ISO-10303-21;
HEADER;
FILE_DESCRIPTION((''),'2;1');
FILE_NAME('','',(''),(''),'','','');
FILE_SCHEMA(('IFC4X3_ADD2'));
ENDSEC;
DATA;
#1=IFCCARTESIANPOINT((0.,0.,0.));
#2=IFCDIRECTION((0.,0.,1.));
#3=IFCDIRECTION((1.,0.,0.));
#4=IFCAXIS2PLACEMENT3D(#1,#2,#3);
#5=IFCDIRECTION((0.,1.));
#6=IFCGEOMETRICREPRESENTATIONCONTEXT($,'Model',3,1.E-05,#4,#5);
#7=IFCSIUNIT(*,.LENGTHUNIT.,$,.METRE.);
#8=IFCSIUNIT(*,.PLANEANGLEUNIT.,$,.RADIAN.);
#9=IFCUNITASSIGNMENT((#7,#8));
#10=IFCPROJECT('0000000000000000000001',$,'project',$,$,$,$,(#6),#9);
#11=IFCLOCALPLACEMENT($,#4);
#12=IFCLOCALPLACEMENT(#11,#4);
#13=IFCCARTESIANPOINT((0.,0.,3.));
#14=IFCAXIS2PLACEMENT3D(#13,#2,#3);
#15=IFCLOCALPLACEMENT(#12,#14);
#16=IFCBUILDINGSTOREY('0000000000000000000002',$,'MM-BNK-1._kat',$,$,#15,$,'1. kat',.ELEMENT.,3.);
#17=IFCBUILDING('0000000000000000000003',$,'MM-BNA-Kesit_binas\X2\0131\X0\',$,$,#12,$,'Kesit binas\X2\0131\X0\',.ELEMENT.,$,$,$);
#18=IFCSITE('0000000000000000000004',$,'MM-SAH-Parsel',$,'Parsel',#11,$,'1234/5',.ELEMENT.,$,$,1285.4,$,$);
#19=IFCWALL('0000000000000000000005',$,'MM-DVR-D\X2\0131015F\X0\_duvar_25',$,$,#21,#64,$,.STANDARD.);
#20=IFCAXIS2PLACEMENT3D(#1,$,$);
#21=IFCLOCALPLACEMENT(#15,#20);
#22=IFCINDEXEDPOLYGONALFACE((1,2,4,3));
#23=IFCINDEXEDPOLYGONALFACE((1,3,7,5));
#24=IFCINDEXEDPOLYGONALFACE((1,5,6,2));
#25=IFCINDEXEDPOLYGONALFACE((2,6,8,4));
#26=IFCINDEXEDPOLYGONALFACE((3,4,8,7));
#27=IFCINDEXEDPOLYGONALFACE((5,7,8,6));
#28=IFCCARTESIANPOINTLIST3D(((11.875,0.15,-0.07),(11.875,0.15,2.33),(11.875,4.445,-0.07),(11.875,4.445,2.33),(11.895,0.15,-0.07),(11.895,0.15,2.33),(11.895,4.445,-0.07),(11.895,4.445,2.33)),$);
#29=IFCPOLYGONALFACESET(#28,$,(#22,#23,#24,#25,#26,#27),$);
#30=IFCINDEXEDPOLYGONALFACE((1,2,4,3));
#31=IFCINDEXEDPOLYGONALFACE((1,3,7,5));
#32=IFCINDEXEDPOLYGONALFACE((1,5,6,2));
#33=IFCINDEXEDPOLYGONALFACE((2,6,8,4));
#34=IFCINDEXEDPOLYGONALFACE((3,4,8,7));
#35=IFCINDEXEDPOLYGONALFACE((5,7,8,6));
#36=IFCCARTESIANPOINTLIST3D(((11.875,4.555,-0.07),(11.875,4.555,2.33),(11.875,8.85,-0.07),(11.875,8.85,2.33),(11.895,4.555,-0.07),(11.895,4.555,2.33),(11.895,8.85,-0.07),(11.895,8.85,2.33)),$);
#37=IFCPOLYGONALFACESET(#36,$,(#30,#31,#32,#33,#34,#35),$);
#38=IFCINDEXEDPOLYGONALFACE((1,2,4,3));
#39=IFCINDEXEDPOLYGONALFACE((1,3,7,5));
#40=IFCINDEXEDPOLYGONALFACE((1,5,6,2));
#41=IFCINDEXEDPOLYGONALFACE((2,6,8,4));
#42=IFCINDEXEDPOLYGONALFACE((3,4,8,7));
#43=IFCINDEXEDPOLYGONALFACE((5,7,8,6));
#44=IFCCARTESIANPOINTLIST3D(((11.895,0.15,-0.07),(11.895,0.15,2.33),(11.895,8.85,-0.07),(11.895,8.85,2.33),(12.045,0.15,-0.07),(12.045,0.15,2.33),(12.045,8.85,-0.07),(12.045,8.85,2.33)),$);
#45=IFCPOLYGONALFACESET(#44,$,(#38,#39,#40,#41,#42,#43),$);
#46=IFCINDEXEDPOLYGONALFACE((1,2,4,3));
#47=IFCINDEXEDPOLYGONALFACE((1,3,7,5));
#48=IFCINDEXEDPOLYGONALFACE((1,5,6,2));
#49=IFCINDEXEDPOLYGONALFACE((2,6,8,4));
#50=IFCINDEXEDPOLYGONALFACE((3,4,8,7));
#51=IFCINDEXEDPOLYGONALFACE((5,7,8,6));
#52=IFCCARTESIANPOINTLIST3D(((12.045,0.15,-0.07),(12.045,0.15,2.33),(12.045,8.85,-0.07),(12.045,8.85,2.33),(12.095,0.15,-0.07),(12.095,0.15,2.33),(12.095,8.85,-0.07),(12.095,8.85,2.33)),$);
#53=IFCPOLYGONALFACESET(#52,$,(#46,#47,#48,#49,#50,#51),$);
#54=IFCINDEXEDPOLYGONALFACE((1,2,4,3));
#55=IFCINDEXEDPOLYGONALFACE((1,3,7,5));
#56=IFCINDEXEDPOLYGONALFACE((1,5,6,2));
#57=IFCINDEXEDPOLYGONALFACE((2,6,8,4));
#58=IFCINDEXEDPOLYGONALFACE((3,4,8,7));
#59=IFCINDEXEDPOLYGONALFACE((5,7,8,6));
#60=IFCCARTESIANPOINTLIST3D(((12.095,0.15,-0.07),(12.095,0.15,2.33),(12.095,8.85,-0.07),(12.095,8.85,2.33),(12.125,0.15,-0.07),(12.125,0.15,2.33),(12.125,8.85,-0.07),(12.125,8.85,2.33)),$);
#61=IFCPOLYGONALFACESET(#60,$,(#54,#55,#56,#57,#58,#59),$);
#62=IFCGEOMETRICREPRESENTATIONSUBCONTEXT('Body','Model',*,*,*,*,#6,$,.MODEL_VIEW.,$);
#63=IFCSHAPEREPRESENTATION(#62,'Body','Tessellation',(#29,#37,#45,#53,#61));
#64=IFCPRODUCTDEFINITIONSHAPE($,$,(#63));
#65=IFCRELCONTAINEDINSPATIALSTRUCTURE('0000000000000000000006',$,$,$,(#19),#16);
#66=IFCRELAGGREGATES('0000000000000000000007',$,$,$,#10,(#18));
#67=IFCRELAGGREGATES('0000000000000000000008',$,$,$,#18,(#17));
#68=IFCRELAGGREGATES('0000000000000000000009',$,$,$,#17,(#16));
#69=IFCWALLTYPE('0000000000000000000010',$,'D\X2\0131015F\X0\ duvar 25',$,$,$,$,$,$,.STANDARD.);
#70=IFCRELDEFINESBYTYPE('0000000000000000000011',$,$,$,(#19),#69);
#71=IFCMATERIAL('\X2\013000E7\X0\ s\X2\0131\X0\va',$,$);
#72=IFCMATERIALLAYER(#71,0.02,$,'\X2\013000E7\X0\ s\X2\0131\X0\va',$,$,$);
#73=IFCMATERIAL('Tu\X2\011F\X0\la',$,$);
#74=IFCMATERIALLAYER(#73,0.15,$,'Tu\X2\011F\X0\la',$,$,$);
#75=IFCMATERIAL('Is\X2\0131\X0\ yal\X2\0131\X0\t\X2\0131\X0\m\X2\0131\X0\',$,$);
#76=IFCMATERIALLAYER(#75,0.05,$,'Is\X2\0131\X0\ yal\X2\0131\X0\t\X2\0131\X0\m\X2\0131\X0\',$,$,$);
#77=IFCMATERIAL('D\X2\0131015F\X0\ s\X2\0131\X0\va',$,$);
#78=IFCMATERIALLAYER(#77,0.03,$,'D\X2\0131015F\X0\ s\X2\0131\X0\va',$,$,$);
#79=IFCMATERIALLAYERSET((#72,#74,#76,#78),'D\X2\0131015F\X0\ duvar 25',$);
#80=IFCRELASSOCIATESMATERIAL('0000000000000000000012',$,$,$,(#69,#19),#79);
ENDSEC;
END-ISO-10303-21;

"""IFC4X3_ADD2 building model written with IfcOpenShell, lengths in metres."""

from ifc_helpers import new_model, si_unit, direction, frame, origin_with_axes, place, context, subcontext, project, spatial, polyline, outline, extrude, material, layer, layer_set, type_object, element, save


model = new_model("IFC4X3_ADD2")

# Units and contexts
model_context = context("Model", 3, precision=1e-05, world=origin_with_axes(), true_north=direction((0.0, 1.0)))
body_context = subcontext(model_context, "Body", "Model", "MODEL_VIEW")
ifc_project = project(units=[si_unit("LENGTHUNIT", "METRE"), si_unit("PLANEANGLEUNIT", "RADIAN")], contexts=[model_context])

# Site, building, storey
site_placement = place(None, origin_with_axes())
site = spatial("IfcSite", under=ifc_project, at=site_placement, Name="MM-SAH-Parsel", ObjectType="Parsel", LongName="1234/5", CompositionType="ELEMENT", RefElevation=1285.4)
building_placement = place(site_placement, origin_with_axes())
building = spatial("IfcBuilding", under=site, at=building_placement, Name="MM-BNA-Kesit_binası", LongName="Kesit binası", CompositionType="ELEMENT")
storey_placement = place(building_placement, frame((0.0, 0.0, 3.0), z_axis=(0.0, 0.0, 1.0), x_axis=(1.0, 0.0, 0.0)))
storey = spatial("IfcBuildingStorey", under=building, at=storey_placement, Name="MM-BNK-1._kat", LongName="1. kat", CompositionType="ELEMENT", Elevation=3.0)

# Shared definitions
ifc_material_1 = material(Name="İç sıva")
ifc_layer_1 = layer(ifc_material_1, 0.02, Name="İç sıva")
ifc_material_2 = material(Name="Tuğla")
ifc_layer_2 = layer(ifc_material_2, 0.15, Name="Tuğla")
ifc_material_3 = material(Name="Isı yalıtımı")
ifc_layer_3 = layer(ifc_material_3, 0.05, Name="Isı yalıtımı")
ifc_material_4 = material(Name="Dış sıva")
ifc_layer_4 = layer(ifc_material_4, 0.03, Name="Dış sıva")
ifc_layer_set_1 = layer_set([ifc_layer_1, ifc_layer_2, ifc_layer_3, ifc_layer_4], Name="Dış duvar 25")
wall_type_1 = type_object("IfcWallType", Name="Dış duvar 25", PredefinedType="STANDARD", material=ifc_layer_set_1)

# Wall
wall_1_placement = place(storey_placement, origin_with_axes())
element("IfcWall", 1, at=wall_1_placement, inside=storey, type_object=wall_type_1, material=ifc_layer_set_1, Name="MM-DVR-Dış_duvar_25", PredefinedType="STANDARD", context=body_context, shape_type="SweptSolid", body=[
    extrude(outline(polyline([(11.895, 0.15), (11.895, 4.445), (11.875, 4.445), (11.875, 0.15), (11.895, 0.15)])), frame((0.0, 0.0, -0.07)), (0.0, 0.0, 1.0), 2.4),
    extrude(outline(polyline([(11.895, 4.555), (11.895, 8.85), (11.875, 8.85), (11.875, 4.555), (11.895, 4.555)])), frame((0.0, 0.0, -0.07)), (0.0, 0.0, 1.0), 2.4),
    extrude(outline(polyline([(12.045, 0.15), (12.045, 8.85), (11.895, 8.85), (11.895, 0.15), (12.045, 0.15)])), frame((0.0, 0.0, -0.07)), (0.0, 0.0, 1.0), 2.4),
    extrude(outline(polyline([(12.095, 0.15), (12.095, 8.85), (12.045, 8.85), (12.045, 0.15), (12.095, 0.15)])), frame((0.0, 0.0, -0.07)), (0.0, 0.0, 1.0), 2.4),
    extrude(outline(polyline([(12.125, 0.15), (12.125, 8.85), (12.095, 8.85), (12.095, 0.15), (12.125, 0.15)])), frame((0.0, 0.0, -0.07)), (0.0, 0.0, 1.0), 2.4),
])

save(model, "model.ifc")
